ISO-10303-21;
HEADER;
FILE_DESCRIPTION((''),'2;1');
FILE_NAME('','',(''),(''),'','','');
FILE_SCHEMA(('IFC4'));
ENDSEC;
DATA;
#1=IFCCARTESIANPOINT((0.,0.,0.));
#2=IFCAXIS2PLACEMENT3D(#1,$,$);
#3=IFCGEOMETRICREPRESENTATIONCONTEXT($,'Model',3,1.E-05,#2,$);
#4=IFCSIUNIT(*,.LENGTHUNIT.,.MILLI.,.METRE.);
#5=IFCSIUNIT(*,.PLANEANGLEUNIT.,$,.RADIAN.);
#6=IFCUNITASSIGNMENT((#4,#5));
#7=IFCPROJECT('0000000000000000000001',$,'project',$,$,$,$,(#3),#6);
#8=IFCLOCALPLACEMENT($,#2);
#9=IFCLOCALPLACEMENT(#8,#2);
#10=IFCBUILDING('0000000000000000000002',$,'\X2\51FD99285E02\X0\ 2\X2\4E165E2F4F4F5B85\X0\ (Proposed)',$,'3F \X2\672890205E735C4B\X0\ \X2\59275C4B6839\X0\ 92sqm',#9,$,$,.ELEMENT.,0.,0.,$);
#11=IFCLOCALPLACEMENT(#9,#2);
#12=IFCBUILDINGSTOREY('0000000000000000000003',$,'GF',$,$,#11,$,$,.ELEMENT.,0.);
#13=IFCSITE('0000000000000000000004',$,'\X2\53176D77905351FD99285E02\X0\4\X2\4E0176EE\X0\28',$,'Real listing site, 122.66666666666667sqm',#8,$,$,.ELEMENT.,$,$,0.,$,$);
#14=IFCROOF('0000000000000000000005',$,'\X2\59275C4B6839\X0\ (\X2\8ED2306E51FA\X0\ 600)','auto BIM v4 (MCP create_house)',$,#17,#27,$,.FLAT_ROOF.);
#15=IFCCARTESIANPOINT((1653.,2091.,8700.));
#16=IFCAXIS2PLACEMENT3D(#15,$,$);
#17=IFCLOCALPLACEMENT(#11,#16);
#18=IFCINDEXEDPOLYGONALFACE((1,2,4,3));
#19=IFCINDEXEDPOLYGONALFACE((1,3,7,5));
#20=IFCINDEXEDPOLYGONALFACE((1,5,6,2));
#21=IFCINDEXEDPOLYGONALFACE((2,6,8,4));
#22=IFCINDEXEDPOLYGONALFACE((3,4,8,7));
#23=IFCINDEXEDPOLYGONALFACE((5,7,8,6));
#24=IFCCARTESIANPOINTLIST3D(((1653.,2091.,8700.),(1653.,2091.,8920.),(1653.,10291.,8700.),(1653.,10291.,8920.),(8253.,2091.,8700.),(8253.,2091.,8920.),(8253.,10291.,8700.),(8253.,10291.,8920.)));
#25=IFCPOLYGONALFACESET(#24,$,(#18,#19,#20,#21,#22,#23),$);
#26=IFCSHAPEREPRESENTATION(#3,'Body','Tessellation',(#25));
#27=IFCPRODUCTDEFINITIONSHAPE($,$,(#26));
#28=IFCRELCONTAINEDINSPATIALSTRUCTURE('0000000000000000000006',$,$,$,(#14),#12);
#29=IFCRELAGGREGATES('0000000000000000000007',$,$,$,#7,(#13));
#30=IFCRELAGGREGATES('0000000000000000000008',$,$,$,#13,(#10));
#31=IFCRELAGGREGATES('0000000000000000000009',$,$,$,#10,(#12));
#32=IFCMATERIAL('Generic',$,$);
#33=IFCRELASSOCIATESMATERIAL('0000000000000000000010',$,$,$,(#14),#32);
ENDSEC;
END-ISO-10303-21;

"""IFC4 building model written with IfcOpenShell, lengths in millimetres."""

from ifc_helpers import new_model, si_unit, frame, frame_2d, origin, place, context, project, spatial, rectangle, extrude, material, element, save


model = new_model("IFC4")

# Units and contexts
model_context = context("Model", 3, precision=1e-05, world=origin())
ifc_project = project(units=[si_unit("LENGTHUNIT", "METRE", prefix="MILLI"), si_unit("PLANEANGLEUNIT", "RADIAN")], contexts=[model_context])

# Site, building, storey
site_placement = place(None, origin())
site = spatial("IfcSite", under=ifc_project, at=site_placement, Name="北海道函館市4丁目28", ObjectType="Real listing site, 122.66666666666667sqm", CompositionType="ELEMENT", RefElevation=0.0)
building_placement = place(site_placement, origin())
building = spatial("IfcBuilding", under=site, at=building_placement, Name="函館市 2世帯住宅 (Proposed)", ObjectType="3F 木造平屋 大屋根 92sqm", CompositionType="ELEMENT", ElevationOfRefHeight=0.0, ElevationOfTerrain=0.0)
storey_placement = place(building_placement, origin())
storey = spatial("IfcBuildingStorey", under=building, at=storey_placement, Name="GF", CompositionType="ELEMENT", Elevation=0.0)

# Shared definitions
ifc_material = material(Name="Generic")

# Roof
roof_placement = place(storey_placement, frame((1653.0, 2091.0, 8700.0)))
element("IfcRoof", 1, at=roof_placement, inside=storey, material=ifc_material, Name="大屋根 (軒の出 600)", Description="auto BIM v4 (MCP create_house)", PredefinedType="FLAT_ROOF", context=model_context, shape_type="SweptSolid", body=[
    extrude(rectangle(XDim=6600.0, YDim=8200.0, at=frame_2d((3300.0, 4100.0))), frame((1653.0, 2091.0, 8700.0)), (0.0, 0.0, 1.0), 220.0),
])

save(model, "model.ifc")
